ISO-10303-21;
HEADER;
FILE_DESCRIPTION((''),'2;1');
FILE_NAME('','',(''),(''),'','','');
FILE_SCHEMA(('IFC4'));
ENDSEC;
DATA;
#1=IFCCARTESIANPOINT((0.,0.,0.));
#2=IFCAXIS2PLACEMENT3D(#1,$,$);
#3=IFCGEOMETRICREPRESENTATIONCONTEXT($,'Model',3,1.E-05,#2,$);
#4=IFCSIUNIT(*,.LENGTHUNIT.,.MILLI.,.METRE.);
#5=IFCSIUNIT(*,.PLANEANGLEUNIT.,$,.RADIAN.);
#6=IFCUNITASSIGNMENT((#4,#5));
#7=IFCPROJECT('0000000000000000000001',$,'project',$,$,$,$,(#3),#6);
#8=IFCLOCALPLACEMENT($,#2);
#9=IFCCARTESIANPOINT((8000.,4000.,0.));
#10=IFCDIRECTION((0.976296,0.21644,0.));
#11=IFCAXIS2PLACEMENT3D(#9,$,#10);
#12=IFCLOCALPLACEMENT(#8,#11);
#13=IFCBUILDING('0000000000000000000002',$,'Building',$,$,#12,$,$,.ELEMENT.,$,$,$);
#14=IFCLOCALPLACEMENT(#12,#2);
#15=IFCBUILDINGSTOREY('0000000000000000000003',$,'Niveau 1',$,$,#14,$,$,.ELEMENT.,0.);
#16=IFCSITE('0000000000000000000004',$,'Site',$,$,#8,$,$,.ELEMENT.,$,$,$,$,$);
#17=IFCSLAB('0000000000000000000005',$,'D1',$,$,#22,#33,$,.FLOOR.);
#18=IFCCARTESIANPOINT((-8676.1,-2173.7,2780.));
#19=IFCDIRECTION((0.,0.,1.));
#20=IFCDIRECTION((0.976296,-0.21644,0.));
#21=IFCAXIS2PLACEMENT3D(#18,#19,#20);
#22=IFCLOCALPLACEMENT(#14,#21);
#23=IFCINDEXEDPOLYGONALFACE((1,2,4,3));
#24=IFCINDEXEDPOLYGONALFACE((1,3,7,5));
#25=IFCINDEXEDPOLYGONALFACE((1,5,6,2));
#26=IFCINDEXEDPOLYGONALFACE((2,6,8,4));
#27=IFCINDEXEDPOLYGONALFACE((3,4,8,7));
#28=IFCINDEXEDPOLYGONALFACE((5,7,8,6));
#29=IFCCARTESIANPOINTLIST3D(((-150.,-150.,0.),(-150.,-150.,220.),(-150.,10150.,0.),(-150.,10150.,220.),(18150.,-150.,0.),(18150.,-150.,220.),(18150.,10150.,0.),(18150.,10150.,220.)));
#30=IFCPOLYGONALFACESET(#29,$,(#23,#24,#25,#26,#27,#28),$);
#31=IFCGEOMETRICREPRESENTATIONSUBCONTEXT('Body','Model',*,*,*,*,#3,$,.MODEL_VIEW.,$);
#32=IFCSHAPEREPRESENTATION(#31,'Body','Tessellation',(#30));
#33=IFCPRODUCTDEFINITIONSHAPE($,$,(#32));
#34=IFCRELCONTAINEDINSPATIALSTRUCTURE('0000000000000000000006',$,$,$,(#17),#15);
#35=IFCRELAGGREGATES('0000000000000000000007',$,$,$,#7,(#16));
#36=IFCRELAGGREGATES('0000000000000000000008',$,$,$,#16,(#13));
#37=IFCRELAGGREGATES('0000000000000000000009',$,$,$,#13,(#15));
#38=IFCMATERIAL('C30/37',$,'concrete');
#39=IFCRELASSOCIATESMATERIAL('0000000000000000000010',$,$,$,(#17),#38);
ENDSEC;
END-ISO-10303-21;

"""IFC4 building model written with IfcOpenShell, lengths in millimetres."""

from ifc_helpers import new_model, si_unit, frame, origin, place, context, subcontext, project, spatial, polyline, outline, extrude, material, element, save


model = new_model("IFC4")

# Units and contexts
model_context = context("Model", 3, precision=1e-05, world=origin())
body_context = subcontext(model_context, "Body", "Model", "MODEL_VIEW")
ifc_project = project(units=[si_unit("LENGTHUNIT", "METRE", prefix="MILLI"), si_unit("PLANEANGLEUNIT", "RADIAN")], contexts=[model_context])

# Site, building, storey
site_placement = place(None, origin())
site = spatial("IfcSite", under=ifc_project, at=site_placement, Name="Site", CompositionType="ELEMENT")
building_placement = place(site_placement, frame((8000.0, 4000.0, 0.0), x_axis=(0.976296, 0.21644, 0.0)))
building = spatial("IfcBuilding", under=site, at=building_placement, Name="Building", CompositionType="ELEMENT")
storey_placement = place(building_placement, origin())
storey = spatial("IfcBuildingStorey", under=building, at=storey_placement, Name="Niveau 1", CompositionType="ELEMENT", Elevation=0.0)

# Shared definitions
ifc_material = material(Name="C30/37", Category="concrete")

# Slab
slab_placement = place(storey_placement, frame((-8676.1, -2173.7, 2780.0), z_axis=(0.0, 0.0, 1.0), x_axis=(0.976296, -0.21644, 0.0)))
element("IfcSlab", 1, at=slab_placement, inside=storey, material=ifc_material, Name="D1", PredefinedType="FLOOR", context=body_context, shape_type="SweptSolid", body=[
    extrude(outline(polyline([(-150.0, -150.0), (18150.0, -150.0), (18150.0, 10150.0), (-150.0, 10150.0), (-150.0, -150.0)])), origin(), (0.0, 0.0, 1.0), 220.0),
])

save(model, "model.ifc")
